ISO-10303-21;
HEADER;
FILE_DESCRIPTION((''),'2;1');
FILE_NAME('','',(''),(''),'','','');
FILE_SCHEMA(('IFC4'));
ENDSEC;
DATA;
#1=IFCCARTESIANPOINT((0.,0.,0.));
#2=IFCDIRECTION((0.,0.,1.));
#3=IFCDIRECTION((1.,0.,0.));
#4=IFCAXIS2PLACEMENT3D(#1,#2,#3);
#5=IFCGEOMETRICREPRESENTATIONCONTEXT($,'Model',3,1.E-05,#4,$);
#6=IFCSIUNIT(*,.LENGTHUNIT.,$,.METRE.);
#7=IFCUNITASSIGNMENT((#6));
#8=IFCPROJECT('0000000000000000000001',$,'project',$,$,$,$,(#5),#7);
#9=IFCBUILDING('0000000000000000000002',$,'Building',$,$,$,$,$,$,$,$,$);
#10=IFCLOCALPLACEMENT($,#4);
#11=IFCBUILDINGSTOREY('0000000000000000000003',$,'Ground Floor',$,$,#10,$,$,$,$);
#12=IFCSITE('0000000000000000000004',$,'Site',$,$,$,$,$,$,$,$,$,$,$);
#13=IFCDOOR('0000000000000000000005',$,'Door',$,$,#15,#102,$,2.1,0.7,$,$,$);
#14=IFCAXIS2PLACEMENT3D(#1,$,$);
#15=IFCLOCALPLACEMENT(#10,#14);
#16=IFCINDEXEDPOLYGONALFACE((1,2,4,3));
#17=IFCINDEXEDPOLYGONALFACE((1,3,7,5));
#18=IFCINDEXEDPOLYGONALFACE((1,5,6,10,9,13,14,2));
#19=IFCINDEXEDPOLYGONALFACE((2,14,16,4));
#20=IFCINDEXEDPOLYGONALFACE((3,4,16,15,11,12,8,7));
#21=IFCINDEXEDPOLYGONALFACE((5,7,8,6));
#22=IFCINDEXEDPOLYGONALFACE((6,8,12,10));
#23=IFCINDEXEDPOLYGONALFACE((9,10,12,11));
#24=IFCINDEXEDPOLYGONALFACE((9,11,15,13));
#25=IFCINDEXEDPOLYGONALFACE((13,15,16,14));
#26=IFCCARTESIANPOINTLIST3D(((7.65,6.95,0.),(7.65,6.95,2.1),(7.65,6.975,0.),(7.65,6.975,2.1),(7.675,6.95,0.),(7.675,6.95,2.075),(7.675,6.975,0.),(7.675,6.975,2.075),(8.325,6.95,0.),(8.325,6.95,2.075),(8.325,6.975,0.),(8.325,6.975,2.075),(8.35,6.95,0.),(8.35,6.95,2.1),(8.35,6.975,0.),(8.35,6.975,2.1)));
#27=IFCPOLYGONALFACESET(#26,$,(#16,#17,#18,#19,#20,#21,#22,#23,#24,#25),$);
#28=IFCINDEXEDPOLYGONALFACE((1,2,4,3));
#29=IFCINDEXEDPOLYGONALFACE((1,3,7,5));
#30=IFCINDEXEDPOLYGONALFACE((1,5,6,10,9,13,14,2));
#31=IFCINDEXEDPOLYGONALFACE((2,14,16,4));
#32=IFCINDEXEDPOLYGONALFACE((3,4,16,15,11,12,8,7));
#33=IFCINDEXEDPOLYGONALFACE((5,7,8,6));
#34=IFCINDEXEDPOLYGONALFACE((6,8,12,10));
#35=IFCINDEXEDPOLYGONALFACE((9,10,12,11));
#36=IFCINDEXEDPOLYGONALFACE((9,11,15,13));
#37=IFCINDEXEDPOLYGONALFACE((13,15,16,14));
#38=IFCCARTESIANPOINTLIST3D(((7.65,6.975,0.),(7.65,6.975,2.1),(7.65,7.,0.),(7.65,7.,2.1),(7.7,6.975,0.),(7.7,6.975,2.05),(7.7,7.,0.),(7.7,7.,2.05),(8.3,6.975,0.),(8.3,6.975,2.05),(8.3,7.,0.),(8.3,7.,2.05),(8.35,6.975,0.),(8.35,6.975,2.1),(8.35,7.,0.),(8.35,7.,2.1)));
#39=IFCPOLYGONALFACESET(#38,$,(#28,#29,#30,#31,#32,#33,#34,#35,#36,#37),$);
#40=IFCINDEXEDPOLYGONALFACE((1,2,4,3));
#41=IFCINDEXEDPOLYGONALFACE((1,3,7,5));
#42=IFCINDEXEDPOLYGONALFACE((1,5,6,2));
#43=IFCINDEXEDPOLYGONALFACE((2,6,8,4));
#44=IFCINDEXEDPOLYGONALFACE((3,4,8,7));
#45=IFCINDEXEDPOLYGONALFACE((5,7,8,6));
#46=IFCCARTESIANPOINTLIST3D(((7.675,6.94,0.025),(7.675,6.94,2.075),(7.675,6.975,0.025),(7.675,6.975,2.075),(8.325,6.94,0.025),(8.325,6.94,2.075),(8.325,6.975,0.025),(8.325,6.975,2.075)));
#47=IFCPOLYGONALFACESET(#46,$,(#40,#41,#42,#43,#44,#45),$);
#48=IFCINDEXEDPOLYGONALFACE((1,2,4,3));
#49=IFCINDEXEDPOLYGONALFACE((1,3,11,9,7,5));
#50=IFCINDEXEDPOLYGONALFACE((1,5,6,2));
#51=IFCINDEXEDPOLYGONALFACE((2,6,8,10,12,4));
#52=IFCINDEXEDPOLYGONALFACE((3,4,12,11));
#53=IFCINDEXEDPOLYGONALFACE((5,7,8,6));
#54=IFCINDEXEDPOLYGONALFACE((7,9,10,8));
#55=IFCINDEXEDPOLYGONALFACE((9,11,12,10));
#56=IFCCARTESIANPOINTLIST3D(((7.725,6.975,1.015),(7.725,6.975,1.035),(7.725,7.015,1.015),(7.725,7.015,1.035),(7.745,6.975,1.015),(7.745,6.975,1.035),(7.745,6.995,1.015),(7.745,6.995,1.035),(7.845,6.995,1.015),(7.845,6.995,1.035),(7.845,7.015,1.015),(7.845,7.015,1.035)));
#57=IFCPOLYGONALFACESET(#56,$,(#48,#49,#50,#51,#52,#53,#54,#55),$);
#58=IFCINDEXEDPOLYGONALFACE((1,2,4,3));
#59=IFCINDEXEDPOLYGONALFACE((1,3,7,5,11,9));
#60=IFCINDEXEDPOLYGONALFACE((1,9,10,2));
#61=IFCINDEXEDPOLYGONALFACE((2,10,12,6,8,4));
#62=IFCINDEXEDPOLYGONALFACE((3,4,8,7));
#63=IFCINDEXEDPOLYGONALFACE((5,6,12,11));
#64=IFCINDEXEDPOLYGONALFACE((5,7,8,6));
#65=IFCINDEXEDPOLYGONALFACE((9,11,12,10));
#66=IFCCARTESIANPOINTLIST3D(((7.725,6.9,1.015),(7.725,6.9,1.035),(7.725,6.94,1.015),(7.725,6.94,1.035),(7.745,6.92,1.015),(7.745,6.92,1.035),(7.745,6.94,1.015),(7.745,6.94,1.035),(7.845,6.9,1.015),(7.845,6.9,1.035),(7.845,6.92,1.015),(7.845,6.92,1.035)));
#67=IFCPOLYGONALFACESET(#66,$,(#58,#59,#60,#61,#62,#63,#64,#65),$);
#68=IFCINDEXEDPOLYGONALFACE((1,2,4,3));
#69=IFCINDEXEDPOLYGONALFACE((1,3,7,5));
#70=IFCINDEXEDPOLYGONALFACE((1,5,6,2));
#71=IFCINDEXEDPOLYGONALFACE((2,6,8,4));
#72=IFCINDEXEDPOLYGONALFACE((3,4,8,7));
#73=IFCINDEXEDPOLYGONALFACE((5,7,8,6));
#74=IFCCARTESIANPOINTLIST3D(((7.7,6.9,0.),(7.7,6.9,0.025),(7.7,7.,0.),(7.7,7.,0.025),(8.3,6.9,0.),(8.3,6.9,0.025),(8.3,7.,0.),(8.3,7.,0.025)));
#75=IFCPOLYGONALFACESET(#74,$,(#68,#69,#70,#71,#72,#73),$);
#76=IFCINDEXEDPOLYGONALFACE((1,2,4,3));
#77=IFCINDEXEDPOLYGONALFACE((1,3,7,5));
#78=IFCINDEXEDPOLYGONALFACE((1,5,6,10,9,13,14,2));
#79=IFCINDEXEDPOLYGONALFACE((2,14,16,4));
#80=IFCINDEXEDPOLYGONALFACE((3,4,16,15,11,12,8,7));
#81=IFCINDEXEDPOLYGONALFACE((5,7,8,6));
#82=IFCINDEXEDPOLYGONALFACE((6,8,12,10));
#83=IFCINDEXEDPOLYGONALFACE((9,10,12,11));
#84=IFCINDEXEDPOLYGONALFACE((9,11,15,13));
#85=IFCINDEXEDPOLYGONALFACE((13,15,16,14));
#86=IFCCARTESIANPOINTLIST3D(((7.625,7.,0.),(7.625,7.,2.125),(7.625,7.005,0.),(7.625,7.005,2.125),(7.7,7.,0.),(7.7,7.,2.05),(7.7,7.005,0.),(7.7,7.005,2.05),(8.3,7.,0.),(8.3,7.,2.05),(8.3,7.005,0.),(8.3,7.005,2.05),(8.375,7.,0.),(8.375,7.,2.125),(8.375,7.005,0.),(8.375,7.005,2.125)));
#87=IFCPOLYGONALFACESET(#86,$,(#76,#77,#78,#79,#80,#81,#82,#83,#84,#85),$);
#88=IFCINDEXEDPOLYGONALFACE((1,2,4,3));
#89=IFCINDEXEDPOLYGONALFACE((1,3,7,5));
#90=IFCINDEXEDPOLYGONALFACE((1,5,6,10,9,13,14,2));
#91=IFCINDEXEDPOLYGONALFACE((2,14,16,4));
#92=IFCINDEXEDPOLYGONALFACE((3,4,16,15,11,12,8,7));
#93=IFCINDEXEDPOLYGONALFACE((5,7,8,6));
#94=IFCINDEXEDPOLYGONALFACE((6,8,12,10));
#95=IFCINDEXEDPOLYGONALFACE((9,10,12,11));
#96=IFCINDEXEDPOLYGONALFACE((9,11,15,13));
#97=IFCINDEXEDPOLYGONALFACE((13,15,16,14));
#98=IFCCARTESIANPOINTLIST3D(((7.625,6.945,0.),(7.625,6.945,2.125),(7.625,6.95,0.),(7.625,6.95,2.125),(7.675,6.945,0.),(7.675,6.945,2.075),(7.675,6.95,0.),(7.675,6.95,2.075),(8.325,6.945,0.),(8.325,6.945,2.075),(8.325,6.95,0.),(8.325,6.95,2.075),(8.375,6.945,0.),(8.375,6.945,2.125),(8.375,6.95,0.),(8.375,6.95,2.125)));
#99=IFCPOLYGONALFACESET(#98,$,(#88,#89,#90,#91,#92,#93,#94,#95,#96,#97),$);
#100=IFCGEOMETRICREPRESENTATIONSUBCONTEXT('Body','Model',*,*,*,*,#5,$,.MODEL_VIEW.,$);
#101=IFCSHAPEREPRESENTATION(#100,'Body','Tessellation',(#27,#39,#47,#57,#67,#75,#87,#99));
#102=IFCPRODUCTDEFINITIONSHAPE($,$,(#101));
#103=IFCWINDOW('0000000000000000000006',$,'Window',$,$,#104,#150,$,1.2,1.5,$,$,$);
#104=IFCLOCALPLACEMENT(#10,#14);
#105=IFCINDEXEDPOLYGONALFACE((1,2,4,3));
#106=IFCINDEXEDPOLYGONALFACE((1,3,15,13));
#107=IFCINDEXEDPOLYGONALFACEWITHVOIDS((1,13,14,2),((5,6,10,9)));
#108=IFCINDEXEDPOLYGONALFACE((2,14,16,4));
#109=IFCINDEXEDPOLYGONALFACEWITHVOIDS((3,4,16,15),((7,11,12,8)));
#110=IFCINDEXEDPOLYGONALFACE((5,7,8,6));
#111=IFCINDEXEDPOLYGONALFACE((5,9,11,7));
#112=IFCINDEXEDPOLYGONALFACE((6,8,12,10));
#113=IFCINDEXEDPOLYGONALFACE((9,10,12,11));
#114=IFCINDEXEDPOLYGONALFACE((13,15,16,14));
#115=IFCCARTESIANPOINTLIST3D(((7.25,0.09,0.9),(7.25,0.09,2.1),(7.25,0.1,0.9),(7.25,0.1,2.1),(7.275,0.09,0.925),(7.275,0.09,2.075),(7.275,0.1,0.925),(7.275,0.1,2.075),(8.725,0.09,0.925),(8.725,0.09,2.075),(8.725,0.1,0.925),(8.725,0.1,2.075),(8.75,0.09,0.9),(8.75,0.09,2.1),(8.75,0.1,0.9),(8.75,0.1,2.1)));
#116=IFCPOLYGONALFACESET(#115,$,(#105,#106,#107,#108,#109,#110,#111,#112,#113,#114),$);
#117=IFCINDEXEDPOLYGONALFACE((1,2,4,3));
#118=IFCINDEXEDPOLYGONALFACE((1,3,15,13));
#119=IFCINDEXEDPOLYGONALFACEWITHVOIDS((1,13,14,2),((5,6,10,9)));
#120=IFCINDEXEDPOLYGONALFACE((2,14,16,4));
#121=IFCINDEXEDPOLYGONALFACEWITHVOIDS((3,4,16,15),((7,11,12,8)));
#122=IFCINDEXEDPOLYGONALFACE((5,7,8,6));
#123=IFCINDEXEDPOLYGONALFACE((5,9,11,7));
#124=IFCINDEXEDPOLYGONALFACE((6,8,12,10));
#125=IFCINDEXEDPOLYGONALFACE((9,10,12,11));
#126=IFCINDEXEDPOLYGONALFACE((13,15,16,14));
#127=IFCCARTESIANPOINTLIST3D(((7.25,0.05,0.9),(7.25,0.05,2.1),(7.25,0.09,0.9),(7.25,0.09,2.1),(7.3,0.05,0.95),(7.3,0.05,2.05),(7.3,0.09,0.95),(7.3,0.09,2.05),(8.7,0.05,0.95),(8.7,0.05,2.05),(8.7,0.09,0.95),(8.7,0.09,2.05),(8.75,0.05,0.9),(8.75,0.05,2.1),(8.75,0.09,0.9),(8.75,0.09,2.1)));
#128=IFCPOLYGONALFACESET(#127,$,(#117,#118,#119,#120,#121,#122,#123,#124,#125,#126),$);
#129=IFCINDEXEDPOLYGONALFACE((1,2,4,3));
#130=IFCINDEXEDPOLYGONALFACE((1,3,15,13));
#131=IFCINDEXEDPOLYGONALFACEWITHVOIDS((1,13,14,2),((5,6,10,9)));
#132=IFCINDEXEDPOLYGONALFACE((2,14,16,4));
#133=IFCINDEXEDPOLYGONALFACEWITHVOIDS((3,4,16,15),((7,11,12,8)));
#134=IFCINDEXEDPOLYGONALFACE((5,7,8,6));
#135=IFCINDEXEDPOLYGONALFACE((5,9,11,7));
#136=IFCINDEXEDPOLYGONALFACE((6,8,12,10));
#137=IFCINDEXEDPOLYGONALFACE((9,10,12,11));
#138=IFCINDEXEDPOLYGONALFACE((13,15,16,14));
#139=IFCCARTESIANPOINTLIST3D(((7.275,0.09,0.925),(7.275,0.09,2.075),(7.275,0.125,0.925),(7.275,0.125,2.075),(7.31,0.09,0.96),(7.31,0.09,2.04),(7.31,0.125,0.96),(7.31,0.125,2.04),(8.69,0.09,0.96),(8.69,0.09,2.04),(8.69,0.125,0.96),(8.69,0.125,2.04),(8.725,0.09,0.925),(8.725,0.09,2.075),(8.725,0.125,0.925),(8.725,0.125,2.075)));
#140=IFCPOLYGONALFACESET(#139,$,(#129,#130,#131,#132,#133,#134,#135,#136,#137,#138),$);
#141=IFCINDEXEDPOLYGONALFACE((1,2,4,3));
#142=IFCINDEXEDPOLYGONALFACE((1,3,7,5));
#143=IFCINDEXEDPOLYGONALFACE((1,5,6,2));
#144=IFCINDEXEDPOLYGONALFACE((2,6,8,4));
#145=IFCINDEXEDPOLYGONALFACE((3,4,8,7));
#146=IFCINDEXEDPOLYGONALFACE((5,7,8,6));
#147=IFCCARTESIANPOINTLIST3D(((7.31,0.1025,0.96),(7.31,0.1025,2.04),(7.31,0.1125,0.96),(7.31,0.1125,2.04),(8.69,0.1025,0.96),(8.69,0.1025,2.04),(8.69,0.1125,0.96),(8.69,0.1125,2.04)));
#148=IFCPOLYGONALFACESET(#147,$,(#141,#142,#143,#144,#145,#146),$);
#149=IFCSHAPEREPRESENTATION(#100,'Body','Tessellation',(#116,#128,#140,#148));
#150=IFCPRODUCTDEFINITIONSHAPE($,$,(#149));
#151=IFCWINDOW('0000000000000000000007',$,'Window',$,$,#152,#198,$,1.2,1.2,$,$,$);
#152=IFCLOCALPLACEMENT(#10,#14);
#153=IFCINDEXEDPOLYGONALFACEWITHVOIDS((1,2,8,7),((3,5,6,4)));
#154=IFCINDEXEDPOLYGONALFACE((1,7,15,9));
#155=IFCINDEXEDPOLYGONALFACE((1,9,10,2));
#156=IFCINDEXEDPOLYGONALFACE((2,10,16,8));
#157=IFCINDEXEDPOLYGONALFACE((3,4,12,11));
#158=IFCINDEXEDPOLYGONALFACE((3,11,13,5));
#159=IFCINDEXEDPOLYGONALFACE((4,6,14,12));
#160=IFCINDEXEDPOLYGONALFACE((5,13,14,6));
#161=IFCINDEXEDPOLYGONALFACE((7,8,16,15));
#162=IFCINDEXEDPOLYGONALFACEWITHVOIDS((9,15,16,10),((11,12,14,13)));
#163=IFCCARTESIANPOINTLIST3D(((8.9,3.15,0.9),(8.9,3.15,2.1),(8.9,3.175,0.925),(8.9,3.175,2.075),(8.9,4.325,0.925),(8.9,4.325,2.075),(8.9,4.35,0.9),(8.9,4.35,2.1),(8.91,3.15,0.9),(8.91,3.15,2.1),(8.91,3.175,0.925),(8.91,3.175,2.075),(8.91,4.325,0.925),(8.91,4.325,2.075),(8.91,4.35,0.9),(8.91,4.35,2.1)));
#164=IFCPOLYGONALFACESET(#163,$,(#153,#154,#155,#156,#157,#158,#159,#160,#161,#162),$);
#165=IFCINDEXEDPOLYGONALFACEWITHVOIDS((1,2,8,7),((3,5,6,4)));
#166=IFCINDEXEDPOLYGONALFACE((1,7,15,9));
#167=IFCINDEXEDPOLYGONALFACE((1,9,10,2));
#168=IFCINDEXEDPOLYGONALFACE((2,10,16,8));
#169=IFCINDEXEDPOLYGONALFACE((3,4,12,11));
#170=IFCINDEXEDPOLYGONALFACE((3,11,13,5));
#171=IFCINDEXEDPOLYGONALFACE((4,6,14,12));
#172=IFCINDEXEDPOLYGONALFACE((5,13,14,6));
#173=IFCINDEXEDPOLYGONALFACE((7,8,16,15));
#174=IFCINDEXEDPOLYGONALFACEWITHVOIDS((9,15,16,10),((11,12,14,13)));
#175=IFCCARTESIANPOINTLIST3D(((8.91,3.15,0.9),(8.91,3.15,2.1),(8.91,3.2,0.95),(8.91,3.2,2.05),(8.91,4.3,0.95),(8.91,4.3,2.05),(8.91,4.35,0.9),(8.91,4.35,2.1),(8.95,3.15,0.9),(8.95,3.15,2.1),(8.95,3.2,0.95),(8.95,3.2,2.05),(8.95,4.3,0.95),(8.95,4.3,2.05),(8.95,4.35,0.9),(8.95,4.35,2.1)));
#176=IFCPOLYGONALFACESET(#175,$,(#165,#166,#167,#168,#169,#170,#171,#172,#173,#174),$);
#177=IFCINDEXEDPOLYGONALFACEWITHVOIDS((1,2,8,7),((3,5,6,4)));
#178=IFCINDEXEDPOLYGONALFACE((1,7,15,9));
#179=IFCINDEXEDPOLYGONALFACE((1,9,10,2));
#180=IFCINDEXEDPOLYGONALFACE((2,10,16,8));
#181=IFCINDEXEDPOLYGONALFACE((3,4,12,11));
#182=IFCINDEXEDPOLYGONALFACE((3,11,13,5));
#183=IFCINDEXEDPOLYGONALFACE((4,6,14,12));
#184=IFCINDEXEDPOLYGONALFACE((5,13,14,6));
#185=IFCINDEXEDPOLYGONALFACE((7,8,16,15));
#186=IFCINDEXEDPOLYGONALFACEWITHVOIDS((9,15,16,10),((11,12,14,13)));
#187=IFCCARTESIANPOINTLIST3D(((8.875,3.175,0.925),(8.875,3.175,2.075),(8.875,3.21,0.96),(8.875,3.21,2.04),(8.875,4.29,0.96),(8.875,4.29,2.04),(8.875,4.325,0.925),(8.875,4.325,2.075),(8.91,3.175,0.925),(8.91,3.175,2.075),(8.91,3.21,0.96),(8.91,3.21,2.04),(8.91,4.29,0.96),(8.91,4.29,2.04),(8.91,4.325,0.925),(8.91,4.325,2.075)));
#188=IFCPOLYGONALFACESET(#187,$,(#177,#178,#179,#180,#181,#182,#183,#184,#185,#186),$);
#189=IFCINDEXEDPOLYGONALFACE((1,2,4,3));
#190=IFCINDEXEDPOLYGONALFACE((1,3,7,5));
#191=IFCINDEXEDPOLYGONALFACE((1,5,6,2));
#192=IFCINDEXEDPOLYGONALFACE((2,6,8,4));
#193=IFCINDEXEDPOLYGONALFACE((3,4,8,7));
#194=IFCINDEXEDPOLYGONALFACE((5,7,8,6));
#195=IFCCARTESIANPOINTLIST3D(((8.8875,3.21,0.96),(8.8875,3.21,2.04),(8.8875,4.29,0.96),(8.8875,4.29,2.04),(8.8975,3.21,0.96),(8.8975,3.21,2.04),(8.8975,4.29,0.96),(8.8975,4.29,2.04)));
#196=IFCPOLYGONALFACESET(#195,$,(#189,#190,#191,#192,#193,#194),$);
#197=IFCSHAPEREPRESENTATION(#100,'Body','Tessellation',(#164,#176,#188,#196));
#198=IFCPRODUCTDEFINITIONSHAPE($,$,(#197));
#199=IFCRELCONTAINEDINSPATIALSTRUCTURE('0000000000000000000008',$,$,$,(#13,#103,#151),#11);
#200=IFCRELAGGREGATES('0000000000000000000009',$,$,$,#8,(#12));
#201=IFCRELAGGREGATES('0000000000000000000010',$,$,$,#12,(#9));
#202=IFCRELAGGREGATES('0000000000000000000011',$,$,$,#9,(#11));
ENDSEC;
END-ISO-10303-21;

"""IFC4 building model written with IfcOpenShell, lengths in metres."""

from ifc_helpers import new_model, si_unit, frame, origin_with_axes, place, context, subcontext, project, spatial, line, indexed_curve, outline, extrude, element, save


model = new_model("IFC4")

# Units and contexts
model_context = context("Model", 3, precision=1e-05, world=origin_with_axes())
body_context = subcontext(model_context, "Body", "Model", "MODEL_VIEW")
ifc_project = project(units=[si_unit("LENGTHUNIT", "METRE")], contexts=[model_context])

# Site, building, storey
site = spatial("IfcSite", under=ifc_project, Name="Site")
building = spatial("IfcBuilding", under=site, Name="Building")
storey_placement = place(None, origin_with_axes())
storey = spatial("IfcBuildingStorey", under=building, at=storey_placement, Name="Ground Floor")

# Door
door_1_placement = place(storey_placement, frame((8.35, 7.0, 0.0), z_axis=(0.0, 0.0, 1.0), x_axis=(-1.0, 0.0, 0.0)))
element("IfcDoor", 1, at=door_1_placement, inside=storey, Name="Door", OverallHeight=2.1, OverallWidth=0.7, context=body_context, shape_type="SweptSolid", body=[
    extrude(outline(indexed_curve([(0.0, 0.0), (0.0, 2.1), (0.7, 2.1), (0.7, 0.0), (0.675, 0.0), (0.675, 2.075), (0.025, 2.075), (0.025, 0.0)], segments=[line(1, 2, 3, 4, 5, 6, 7, 8, 1)])), frame((0.0, 0.025, 0.0), z_axis=(0.0, -1.0, 0.0), x_axis=(1.0, 0.0, 0.0)), (0.0, 0.0, -1.0), 0.025),
    extrude(outline(indexed_curve([(0.0, 0.0), (0.0, 2.1), (0.7, 2.1), (0.7, 0.0), (0.65, 0.0), (0.65, 2.05), (0.05, 2.05), (0.05, 0.0)], segments=[line(1, 2, 3, 4, 5, 6, 7, 8, 1)])), frame((0.0, 0.0, 0.0), z_axis=(0.0, -1.0, 0.0), x_axis=(1.0, 0.0, 0.0)), (0.0, 0.0, -1.0), 0.025),
    extrude(outline(indexed_curve([(0.0, 0.0), (0.65, 0.0), (0.65, 0.035), (0.0, 0.035)], segments=[line(1, 2, 3, 4, 1)])), frame((0.025, 0.025, 0.025), z_axis=(0.0, 0.0, 1.0), x_axis=(1.0, 0.0, 0.0)), (0.0, 0.0, 1.0), 2.05),
    extrude(outline(indexed_curve([(0.0, 0.0), (0.0, -0.04), (-0.12, -0.04), (-0.12, -0.02), (-0.02, -0.02), (-0.02, 0.0)], segments=[line(1, 2, 3, 4, 5, 6, 1)])), frame((0.625, 0.025, 1.015), z_axis=(0.0, 0.0, 1.0), x_axis=(1.0, 0.0, 0.0)), (0.0, 0.0, 1.0), 0.02),
    extrude(outline(indexed_curve([(0.0, 0.0), (0.0, 0.04), (-0.12, 0.04), (-0.12, 0.02), (-0.02, 0.02), (-0.02, 0.0)], segments=[line(1, 2, 3, 4, 5, 6, 1)])), frame((0.625, 0.06, 1.015), z_axis=(0.0, 0.0, 1.0), x_axis=(1.0, 0.0, 0.0)), (0.0, 0.0, 1.0), 0.02),
    extrude(outline(indexed_curve([(0.0, 0.0), (0.6, 0.0), (0.6, 0.1), (0.0, 0.1)], segments=[line(1, 2, 3, 4, 1)])), frame((0.05, 0.0, 0.0), z_axis=(0.0, 0.0, 1.0), x_axis=(1.0, 0.0, 0.0)), (0.0, 0.0, 1.0), 0.025),
    extrude(outline(indexed_curve([(0.0, 0.0), (0.0, 2.125), (0.75, 2.125), (0.75, 0.0), (0.675, 0.0), (0.675, 2.05), (0.075, 2.05), (0.075, 0.0)], segments=[line(1, 2, 3, 4, 5, 6, 7, 8, 1)])), frame((-0.025, -0.005, 0.0), z_axis=(0.0, -1.0, 0.0), x_axis=(1.0, 0.0, 0.0)), (0.0, 0.0, -1.0), 0.005),
    extrude(outline(indexed_curve([(0.0, 0.0), (0.0, 2.125), (0.75, 2.125), (0.75, 0.0), (0.7, 0.0), (0.7, 2.075), (0.05, 2.075), (0.05, 0.0)], segments=[line(1, 2, 3, 4, 5, 6, 7, 8, 1)])), frame((-0.025, 0.05, 0.0), z_axis=(0.0, -1.0, 0.0), x_axis=(1.0, 0.0, 0.0)), (0.0, 0.0, -1.0), 0.005),
])

# Windows
window_1_placement = place(storey_placement, frame((7.25, 0.0, 0.9), z_axis=(0.0, 0.0, 1.0), x_axis=(1.0, 0.0, 0.0)))
element("IfcWindow", 2, at=window_1_placement, inside=storey, Name="Window", OverallHeight=1.2, OverallWidth=1.5, context=body_context, shape_type="SweptSolid", body=[
    extrude(outline(indexed_curve([(0.0, 0.0), (1.5, 0.0), (1.5, 1.2), (0.0, 1.2)], segments=[line(1, 2, 3, 4, 1)]), holes=[indexed_curve([(0.025, 0.025), (1.475, 0.025), (1.475, 1.175), (0.025, 1.175)], segments=[line(1, 2, 3, 4, 1)])]), frame((0.0, 0.09, 0.0), z_axis=(0.0, -1.0, 0.0), x_axis=(1.0, 0.0, 0.0)), (0.0, 0.0, -1.0), 0.01),
    extrude(outline(indexed_curve([(0.0, 0.0), (1.5, 0.0), (1.5, 1.2), (0.0, 1.2)], segments=[line(1, 2, 3, 4, 1)]), holes=[indexed_curve([(0.05, 0.05), (1.45, 0.05), (1.45, 1.15), (0.05, 1.15)], segments=[line(1, 2, 3, 4, 1)])]), frame((0.0, 0.05, 0.0), z_axis=(0.0, -1.0, 0.0), x_axis=(1.0, 0.0, 0.0)), (0.0, 0.0, -1.0), 0.04),
    extrude(outline(indexed_curve([(0.0, 0.0), (1.45, 0.0), (1.45, 1.15), (0.0, 1.15)], segments=[line(1, 2, 3, 4, 1)]), holes=[indexed_curve([(0.035, 0.035), (1.415, 0.035), (1.415, 1.115), (0.035, 1.115)], segments=[line(1, 2, 3, 4, 1)])]), frame((0.025, 0.09, 0.025), z_axis=(0.0, -1.0, 0.0), x_axis=(1.0, 0.0, 0.0)), (0.0, 0.0, -1.0), 0.035),
    extrude(outline(indexed_curve([(0.035, 0.035), (1.415, 0.035), (1.415, 1.115), (0.035, 1.115)], segments=[line(1, 2, 3, 4, 1)])), frame((0.025, 0.1025, 0.025), z_axis=(0.0, -1.0, 0.0), x_axis=(1.0, 0.0, 0.0)), (0.0, 0.0, -1.0), 0.01),
])
window_2_placement = place(storey_placement, frame((9.0, 3.15, 0.9), z_axis=(0.0, 0.0, 1.0), x_axis=(0.0, 1.0, 0.0)))
element("IfcWindow", 3, at=window_2_placement, inside=storey, Name="Window", OverallHeight=1.2, OverallWidth=1.2, context=body_context, shape_type="SweptSolid", body=[
    extrude(outline(indexed_curve([(0.0, 0.0), (1.2, 0.0), (1.2, 1.2), (0.0, 1.2)], segments=[line(1, 2, 3, 4, 1)]), holes=[indexed_curve([(0.025, 0.025), (1.175, 0.025), (1.175, 1.175), (0.025, 1.175)], segments=[line(1, 2, 3, 4, 1)])]), frame((0.0, 0.09, 0.0), z_axis=(0.0, -1.0, 0.0), x_axis=(1.0, 0.0, 0.0)), (0.0, 0.0, -1.0), 0.01),
    extrude(outline(indexed_curve([(0.0, 0.0), (1.2, 0.0), (1.2, 1.2), (0.0, 1.2)], segments=[line(1, 2, 3, 4, 1)]), holes=[indexed_curve([(0.05, 0.05), (1.15, 0.05), (1.15, 1.15), (0.05, 1.15)], segments=[line(1, 2, 3, 4, 1)])]), frame((0.0, 0.05, 0.0), z_axis=(0.0, -1.0, 0.0), x_axis=(1.0, 0.0, 0.0)), (0.0, 0.0, -1.0), 0.04),
    extrude(outline(indexed_curve([(0.0, 0.0), (1.15, 0.0), (1.15, 1.15), (0.0, 1.15)], segments=[line(1, 2, 3, 4, 1)]), holes=[indexed_curve([(0.035, 0.035), (1.115, 0.035), (1.115, 1.115), (0.035, 1.115)], segments=[line(1, 2, 3, 4, 1)])]), frame((0.025, 0.09, 0.025), z_axis=(0.0, -1.0, 0.0), x_axis=(1.0, 0.0, 0.0)), (0.0, 0.0, -1.0), 0.035),
    extrude(outline(indexed_curve([(0.035, 0.035), (1.115, 0.035), (1.115, 1.115), (0.035, 1.115)], segments=[line(1, 2, 3, 4, 1)])), frame((0.025, 0.1025, 0.025), z_axis=(0.0, -1.0, 0.0), x_axis=(1.0, 0.0, 0.0)), (0.0, 0.0, -1.0), 0.01),
])

save(model, "model.ifc")
